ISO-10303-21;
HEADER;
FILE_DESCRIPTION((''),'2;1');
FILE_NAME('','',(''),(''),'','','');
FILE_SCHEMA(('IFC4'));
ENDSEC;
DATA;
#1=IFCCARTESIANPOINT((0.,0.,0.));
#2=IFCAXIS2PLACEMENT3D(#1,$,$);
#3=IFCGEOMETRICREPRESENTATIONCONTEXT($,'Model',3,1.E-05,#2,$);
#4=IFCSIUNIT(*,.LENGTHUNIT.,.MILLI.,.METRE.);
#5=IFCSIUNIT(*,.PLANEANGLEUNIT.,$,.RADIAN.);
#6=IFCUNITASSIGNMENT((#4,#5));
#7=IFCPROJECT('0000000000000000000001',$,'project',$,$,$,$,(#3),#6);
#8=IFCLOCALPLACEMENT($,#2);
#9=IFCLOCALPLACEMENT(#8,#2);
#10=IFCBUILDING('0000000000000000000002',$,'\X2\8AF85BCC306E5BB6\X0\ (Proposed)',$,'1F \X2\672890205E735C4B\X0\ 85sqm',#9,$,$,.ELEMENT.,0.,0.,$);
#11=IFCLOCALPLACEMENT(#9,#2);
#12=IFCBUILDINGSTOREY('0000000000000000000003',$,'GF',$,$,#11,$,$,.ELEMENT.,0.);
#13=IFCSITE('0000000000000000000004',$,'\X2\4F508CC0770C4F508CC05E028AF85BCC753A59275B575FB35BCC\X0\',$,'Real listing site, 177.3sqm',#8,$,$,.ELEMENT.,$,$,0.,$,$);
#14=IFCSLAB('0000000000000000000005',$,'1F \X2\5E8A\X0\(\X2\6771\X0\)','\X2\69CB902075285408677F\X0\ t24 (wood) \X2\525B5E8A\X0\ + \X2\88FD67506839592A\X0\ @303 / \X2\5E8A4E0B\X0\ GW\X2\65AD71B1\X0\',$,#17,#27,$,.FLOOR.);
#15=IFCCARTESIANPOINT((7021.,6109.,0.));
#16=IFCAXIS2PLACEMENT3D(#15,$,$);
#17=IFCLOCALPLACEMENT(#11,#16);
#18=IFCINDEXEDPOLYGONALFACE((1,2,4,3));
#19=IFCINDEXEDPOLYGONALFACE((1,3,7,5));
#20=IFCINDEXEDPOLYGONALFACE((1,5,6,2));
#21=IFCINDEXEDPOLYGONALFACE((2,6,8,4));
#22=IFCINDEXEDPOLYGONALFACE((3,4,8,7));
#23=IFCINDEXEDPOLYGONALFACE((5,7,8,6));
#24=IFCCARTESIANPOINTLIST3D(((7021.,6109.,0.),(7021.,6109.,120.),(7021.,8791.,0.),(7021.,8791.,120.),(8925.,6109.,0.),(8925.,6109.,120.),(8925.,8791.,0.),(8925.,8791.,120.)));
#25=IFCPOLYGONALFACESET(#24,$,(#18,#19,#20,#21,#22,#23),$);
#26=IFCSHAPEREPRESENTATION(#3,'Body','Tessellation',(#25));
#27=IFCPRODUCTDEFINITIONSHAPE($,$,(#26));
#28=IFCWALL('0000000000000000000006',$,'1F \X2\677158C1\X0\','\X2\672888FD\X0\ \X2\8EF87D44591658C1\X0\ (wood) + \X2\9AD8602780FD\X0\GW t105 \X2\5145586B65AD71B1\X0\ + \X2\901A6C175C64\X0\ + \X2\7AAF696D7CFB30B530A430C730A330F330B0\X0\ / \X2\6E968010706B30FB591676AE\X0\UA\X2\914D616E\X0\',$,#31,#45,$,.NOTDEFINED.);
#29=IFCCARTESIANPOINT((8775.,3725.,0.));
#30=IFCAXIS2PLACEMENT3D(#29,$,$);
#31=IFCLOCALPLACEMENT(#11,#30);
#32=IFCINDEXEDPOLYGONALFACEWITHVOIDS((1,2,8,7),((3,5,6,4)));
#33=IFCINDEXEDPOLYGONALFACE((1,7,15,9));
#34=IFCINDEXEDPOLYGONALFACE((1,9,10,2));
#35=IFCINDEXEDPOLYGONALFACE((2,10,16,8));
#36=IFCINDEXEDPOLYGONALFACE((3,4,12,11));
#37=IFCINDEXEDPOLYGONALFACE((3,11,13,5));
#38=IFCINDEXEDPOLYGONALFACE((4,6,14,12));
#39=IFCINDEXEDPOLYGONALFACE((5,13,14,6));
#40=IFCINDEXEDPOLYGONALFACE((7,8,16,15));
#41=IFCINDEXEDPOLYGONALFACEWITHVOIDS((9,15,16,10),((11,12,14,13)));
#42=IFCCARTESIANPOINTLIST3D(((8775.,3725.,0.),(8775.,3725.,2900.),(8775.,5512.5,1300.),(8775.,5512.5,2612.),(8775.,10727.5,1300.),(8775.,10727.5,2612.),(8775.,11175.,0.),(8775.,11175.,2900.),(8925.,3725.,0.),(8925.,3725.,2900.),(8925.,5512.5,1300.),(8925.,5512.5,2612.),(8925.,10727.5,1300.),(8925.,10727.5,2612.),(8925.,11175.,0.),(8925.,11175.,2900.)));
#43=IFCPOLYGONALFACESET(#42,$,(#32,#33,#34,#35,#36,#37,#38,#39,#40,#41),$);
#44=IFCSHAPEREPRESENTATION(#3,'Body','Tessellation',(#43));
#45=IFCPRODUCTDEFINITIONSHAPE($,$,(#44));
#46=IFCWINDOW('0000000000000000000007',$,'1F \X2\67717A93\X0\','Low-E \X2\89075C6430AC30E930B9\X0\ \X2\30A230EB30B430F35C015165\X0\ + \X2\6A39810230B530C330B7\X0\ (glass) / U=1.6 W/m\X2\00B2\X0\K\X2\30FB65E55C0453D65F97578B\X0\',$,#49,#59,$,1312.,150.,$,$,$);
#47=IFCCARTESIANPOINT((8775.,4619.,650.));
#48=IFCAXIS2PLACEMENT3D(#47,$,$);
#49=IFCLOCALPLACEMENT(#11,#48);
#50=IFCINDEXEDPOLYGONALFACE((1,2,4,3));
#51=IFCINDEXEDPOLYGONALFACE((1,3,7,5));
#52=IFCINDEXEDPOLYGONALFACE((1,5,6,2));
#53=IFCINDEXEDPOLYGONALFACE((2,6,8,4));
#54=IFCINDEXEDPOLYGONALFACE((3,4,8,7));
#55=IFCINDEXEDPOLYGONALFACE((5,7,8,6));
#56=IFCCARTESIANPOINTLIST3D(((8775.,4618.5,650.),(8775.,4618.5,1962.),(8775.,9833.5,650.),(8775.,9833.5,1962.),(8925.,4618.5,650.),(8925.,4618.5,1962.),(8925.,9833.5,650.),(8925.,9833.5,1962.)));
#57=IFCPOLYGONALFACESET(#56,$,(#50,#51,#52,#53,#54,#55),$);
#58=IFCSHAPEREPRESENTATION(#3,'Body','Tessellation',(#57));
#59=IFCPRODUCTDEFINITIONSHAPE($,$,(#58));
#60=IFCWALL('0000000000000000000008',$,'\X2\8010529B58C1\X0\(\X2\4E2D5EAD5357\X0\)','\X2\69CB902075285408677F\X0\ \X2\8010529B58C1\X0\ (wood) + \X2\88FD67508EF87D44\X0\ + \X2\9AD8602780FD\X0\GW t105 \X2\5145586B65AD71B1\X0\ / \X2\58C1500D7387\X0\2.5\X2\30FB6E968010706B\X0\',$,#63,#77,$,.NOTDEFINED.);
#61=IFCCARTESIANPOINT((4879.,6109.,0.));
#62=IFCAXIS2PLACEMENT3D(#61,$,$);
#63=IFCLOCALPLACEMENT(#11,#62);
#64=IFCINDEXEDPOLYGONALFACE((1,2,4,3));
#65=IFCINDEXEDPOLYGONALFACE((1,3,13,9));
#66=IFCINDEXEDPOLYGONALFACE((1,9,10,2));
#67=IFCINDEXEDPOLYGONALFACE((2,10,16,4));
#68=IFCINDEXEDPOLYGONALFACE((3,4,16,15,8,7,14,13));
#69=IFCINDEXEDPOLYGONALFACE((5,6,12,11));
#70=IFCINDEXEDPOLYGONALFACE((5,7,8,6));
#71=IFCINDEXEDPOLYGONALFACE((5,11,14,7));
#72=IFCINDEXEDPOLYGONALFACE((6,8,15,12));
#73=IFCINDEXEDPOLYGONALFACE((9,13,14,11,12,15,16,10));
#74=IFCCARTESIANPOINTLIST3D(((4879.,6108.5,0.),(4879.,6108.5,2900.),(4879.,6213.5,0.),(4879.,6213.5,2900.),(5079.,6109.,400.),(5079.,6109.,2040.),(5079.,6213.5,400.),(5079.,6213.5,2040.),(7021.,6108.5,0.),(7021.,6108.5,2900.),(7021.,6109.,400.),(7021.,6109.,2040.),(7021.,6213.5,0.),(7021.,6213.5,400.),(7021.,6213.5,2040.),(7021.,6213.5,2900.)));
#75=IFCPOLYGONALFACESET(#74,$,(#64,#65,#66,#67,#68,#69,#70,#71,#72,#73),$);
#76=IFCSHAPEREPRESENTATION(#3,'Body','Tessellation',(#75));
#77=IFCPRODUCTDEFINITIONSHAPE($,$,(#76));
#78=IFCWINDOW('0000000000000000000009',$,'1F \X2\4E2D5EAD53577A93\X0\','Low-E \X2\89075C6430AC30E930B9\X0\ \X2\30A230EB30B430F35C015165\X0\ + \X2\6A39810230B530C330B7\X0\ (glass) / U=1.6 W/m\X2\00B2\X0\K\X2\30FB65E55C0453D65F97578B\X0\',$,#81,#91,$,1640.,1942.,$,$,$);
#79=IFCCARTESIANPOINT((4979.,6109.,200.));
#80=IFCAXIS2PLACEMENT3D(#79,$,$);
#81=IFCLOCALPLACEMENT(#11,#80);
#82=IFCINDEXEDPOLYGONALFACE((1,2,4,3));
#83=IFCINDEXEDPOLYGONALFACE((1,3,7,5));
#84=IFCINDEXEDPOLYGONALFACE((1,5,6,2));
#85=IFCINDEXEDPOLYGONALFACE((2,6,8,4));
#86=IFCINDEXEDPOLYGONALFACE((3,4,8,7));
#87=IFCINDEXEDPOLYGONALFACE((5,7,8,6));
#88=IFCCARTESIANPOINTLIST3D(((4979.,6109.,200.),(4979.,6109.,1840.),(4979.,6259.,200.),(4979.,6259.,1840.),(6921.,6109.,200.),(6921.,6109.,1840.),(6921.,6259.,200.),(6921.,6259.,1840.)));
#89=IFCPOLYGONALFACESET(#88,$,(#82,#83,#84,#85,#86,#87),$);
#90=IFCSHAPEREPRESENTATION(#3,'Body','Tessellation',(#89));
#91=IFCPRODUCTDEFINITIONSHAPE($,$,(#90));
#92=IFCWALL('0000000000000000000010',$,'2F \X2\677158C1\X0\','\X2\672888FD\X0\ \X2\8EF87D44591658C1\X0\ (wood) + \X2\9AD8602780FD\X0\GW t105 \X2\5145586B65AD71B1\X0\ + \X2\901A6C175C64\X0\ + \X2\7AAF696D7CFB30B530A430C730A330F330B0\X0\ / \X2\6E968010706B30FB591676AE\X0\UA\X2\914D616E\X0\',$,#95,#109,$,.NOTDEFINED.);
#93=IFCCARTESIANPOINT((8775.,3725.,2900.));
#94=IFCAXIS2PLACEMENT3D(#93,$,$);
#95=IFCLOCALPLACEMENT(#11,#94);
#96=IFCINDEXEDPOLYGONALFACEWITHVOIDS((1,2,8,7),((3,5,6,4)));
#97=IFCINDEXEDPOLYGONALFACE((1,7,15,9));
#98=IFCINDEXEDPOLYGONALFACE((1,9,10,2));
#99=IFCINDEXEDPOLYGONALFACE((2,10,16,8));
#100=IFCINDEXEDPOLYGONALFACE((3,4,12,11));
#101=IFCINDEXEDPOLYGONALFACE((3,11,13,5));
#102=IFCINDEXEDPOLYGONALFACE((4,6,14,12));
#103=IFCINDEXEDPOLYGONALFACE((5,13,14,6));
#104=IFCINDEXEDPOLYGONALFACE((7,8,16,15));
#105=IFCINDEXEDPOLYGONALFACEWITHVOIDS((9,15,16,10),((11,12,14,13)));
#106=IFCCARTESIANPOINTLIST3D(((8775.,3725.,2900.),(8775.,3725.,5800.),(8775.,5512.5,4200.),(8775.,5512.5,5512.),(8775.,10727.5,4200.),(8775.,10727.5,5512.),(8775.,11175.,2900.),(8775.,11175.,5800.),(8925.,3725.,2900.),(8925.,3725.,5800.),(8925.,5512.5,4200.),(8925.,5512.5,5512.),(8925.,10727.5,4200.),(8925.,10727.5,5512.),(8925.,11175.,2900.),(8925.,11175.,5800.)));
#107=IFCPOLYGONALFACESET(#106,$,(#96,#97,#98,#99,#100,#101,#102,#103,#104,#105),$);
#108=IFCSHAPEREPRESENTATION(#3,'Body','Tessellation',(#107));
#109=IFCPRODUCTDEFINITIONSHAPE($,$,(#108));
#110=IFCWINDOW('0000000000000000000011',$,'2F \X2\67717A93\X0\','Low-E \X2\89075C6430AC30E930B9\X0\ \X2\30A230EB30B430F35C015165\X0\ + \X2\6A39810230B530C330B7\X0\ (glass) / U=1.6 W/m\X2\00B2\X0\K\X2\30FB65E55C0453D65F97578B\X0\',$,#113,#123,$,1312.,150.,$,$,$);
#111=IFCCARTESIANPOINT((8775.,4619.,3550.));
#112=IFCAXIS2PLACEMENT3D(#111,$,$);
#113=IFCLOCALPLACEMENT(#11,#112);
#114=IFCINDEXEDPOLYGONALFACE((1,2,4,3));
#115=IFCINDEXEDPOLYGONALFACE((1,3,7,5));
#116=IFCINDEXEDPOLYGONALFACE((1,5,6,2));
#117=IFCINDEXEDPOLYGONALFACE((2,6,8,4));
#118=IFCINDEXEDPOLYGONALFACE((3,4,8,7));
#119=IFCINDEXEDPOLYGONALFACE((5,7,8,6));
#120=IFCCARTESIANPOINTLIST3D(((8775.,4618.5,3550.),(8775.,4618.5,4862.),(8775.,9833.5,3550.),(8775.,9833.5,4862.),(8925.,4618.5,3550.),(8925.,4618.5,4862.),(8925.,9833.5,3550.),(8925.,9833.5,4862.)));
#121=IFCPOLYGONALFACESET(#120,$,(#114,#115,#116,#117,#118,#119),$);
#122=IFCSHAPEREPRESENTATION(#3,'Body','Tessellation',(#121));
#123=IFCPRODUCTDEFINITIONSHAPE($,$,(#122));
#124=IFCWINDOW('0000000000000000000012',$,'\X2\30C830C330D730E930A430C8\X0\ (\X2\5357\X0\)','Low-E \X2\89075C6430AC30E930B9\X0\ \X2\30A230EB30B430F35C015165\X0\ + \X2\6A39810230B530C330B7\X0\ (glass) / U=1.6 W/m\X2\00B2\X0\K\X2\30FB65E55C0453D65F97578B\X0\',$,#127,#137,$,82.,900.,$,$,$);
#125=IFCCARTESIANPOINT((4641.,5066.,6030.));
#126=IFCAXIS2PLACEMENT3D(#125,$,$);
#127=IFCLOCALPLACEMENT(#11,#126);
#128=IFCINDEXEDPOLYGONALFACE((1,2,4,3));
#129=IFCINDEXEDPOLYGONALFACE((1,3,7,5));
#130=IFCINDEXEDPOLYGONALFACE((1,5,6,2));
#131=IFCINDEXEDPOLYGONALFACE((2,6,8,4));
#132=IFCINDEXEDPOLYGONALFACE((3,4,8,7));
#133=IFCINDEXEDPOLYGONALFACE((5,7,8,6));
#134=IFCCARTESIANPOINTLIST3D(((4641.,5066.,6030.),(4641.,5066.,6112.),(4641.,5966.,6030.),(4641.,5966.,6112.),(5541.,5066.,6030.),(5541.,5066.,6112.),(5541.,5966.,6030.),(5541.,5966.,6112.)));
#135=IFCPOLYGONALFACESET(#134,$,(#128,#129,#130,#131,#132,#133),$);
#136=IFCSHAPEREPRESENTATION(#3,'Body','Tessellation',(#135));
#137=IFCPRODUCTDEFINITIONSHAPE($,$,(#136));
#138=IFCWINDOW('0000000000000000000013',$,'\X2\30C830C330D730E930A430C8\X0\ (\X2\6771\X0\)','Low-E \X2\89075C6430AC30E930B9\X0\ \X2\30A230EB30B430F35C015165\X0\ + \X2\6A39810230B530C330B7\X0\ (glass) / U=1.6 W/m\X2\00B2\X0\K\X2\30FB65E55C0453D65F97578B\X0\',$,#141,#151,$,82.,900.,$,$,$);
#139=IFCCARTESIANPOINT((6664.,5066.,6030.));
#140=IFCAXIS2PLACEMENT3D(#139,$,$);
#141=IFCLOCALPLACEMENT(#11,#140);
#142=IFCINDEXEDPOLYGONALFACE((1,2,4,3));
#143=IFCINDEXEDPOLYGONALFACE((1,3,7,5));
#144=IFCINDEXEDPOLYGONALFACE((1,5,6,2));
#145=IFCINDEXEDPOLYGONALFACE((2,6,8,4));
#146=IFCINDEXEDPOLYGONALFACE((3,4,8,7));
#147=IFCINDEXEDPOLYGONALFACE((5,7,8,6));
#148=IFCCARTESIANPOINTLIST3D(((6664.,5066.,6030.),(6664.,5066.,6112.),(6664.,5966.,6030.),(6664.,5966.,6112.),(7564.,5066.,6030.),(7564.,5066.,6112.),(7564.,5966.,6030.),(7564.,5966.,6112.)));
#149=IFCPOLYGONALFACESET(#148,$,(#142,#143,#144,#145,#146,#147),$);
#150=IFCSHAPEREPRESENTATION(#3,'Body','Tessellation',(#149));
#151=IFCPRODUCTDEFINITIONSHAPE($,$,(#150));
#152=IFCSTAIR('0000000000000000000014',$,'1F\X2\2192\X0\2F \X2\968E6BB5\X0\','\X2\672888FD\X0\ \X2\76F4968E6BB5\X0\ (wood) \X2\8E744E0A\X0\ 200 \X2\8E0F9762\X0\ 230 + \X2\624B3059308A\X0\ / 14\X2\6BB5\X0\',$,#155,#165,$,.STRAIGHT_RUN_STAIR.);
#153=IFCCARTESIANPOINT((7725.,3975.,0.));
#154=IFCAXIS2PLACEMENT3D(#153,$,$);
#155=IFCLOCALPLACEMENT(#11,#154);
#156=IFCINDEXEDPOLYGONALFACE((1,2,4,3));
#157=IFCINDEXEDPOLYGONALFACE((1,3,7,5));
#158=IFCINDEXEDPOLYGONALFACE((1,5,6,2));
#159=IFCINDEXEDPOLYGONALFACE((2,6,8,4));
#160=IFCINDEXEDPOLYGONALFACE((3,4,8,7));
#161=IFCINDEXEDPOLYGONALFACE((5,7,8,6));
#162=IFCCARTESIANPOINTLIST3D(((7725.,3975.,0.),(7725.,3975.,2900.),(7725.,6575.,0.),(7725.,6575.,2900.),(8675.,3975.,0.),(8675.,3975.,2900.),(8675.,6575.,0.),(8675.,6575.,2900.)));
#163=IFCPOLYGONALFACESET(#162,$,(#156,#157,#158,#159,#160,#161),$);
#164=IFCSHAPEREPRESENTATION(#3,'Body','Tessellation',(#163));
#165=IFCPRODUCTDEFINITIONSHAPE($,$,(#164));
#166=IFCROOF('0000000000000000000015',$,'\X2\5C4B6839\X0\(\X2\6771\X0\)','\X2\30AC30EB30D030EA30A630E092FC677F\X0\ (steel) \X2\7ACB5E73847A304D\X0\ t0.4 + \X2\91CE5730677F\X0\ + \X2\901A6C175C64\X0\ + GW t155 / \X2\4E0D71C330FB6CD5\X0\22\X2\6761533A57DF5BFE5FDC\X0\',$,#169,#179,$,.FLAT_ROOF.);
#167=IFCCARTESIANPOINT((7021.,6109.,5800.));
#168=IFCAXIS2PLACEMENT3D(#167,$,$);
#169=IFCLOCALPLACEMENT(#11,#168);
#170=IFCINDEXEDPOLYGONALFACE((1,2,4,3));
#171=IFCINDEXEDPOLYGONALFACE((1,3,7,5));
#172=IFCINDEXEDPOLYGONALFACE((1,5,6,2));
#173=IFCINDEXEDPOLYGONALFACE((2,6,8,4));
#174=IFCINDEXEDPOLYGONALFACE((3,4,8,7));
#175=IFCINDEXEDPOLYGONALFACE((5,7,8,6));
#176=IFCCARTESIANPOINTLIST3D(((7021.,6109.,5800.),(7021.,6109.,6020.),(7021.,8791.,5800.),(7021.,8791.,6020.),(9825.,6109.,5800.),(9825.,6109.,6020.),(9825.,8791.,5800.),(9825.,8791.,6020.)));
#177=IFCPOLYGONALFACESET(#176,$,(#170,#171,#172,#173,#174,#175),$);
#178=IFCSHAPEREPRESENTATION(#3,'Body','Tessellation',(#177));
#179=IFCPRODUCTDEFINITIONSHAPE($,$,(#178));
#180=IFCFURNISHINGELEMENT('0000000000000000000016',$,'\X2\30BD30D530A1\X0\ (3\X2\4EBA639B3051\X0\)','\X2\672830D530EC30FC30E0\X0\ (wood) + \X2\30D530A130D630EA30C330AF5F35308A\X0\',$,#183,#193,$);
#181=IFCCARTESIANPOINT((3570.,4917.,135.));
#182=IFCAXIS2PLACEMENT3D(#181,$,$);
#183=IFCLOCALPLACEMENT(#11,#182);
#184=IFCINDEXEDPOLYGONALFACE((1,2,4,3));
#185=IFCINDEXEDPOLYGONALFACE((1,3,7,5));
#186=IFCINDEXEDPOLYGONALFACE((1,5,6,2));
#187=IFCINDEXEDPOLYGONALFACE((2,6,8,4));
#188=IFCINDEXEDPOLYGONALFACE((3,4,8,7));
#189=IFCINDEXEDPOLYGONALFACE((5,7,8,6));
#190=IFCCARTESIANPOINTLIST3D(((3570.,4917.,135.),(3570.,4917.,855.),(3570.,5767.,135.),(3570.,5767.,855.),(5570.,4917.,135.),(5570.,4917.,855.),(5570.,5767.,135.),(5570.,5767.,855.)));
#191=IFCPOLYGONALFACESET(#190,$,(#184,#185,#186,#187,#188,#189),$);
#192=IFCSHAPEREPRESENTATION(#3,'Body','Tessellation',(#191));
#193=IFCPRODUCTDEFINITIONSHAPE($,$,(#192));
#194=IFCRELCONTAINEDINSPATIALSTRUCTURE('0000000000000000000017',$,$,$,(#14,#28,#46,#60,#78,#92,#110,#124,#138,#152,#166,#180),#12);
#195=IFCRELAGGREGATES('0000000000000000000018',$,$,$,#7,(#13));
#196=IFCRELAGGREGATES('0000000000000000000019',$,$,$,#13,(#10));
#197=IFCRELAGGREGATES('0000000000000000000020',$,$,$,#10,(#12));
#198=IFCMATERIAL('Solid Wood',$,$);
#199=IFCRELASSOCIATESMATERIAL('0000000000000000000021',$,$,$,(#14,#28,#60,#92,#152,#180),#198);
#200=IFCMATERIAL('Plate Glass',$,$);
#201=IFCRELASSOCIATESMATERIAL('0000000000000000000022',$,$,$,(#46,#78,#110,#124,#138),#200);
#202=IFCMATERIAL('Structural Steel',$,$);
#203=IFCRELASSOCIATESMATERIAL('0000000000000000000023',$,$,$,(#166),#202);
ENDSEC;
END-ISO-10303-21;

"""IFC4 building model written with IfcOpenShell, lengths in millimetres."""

from ifc_helpers import new_model, si_unit, frame, frame_2d, origin, place, context, project, spatial, rectangle, extrude, material, element, fill, save


model = new_model("IFC4")

# Units and contexts
model_context = context("Model", 3, precision=1e-05, world=origin())
ifc_project = project(units=[si_unit("LENGTHUNIT", "METRE", prefix="MILLI"), si_unit("PLANEANGLEUNIT", "RADIAN")], contexts=[model_context])

# Site, building, storey
site_placement = place(None, origin())
site = spatial("IfcSite", under=ifc_project, at=site_placement, Name="佐賀県佐賀市諸富町大字徳富", ObjectType="Real listing site, 177.3sqm", CompositionType="ELEMENT", RefElevation=0.0)
building_placement = place(site_placement, origin())
building = spatial("IfcBuilding", under=site, at=building_placement, Name="諸富の家 (Proposed)", ObjectType="1F 木造平屋 85sqm", CompositionType="ELEMENT", ElevationOfRefHeight=0.0, ElevationOfTerrain=0.0)
storey_placement = place(building_placement, origin())
storey = spatial("IfcBuildingStorey", under=building, at=storey_placement, Name="GF", CompositionType="ELEMENT", Elevation=0.0)

# Slab
ifc_material_1 = material(Name="Solid Wood")
slab_placement = place(storey_placement, frame((7021.0, 6109.0, 0.0)))
element("IfcSlab", 1, at=slab_placement, inside=storey, material=ifc_material_1, Name="1F 床(東)", Description="構造用合板 t24 (wood) 剛床 + 製材根太 @303 / 床下 GW断熱", PredefinedType="FLOOR", context=model_context, shape_type="SweptSolid", body=[
    extrude(rectangle(XDim=1904.0, YDim=2682.0, at=frame_2d((952.0, 1341.0))), frame((7021.0, 6109.0, 0.0)), (0.0, 0.0, 1.0), 120.0),
])

# Walls, openings, windows
wall_1_placement = place(storey_placement, frame((8775.0, 3725.0, 0.0)))
wall_1 = element("IfcWall", 2, at=wall_1_placement, inside=storey, material=ifc_material_1, Name="1F 東壁", Description="木製 軸組外壁 (wood) + 高性能GW t105 充填断熱 + 通気層 + 窯業系サイディング / 準耐火・外皮UA配慮", PredefinedType="NOTDEFINED", context=model_context, shape_type="SweptSolid", body=[
    extrude(rectangle(XDim=150.0, YDim=7450.0, at=frame_2d((75.0, 3725.0))), frame((8775.0, 3725.0, 0.0)), (0.0, 0.0, 1.0), 2900.0),
])
opening_1_placement = place(storey_placement, frame((8775.0, 4619.0, 650.0)))
opening_1 = element("IfcOpeningElement", 3, at=opening_1_placement, cuts=wall_1, PredefinedType="NOTDEFINED", context=model_context, shape_type="SweptSolid", body=[
    extrude(rectangle(XDim=150.0, YDim=5215.0, at=frame_2d((75.0, 2607.0))), frame((8775.0, 4619.0, 650.0)), (0.0, 0.0, 1.0), 1312.0),
])
ifc_material_2 = material(Name="Plate Glass")
window_1_placement = place(storey_placement, frame((8775.0, 4619.0, 650.0)))
window_1 = element("IfcWindow", 4, at=window_1_placement, inside=storey, material=ifc_material_2, Name="1F 東窓", Description="Low-E 複層ガラス アルゴン封入 + 樹脂サッシ (glass) / U=1.6 W/m²K・日射取得型", OverallHeight=1312.0, OverallWidth=150.0, context=model_context, shape_type="SweptSolid", body=[
    extrude(rectangle(XDim=150.0, YDim=5215.0, at=frame_2d((75.0, 2607.0))), frame((8775.0, 4619.0, 650.0)), (0.0, 0.0, 1.0), 1312.0),
])
fill(opening_1, window_1)
wall_2_placement = place(storey_placement, frame((4879.0, 6109.0, 0.0)))
wall_2 = element("IfcWall", 5, at=wall_2_placement, inside=storey, material=ifc_material_1, Name="耐力壁(中庭南)", Description="構造用合板 耐力壁 (wood) + 製材軸組 + 高性能GW t105 充填断熱 / 壁倍率2.5・準耐火", PredefinedType="NOTDEFINED", context=model_context, shape_type="SweptSolid", body=[
    extrude(rectangle(XDim=2142.0, YDim=105.0, at=frame_2d((1071.0, 52.0))), frame((4879.0, 6109.0, 0.0)), (0.0, 0.0, 1.0), 2900.0),
])
opening_2_placement = place(storey_placement, frame((4979.0, 6109.0, 200.0)))
opening_2 = element("IfcOpeningElement", 6, at=opening_2_placement, cuts=wall_2, PredefinedType="NOTDEFINED", context=model_context, shape_type="SweptSolid", body=[
    extrude(rectangle(XDim=1942.0, YDim=150.0, at=frame_2d((971.0, 75.0))), frame((4979.0, 6109.0, 200.0)), (0.0, 0.0, 1.0), 1640.0),
])
window_2_placement = place(storey_placement, frame((4979.0, 6109.0, 200.0)))
window_2 = element("IfcWindow", 7, at=window_2_placement, inside=storey, material=ifc_material_2, Name="1F 中庭南窓", Description="Low-E 複層ガラス アルゴン封入 + 樹脂サッシ (glass) / U=1.6 W/m²K・日射取得型", OverallHeight=1640.0, OverallWidth=1942.0, context=model_context, shape_type="SweptSolid", body=[
    extrude(rectangle(XDim=1942.0, YDim=150.0, at=frame_2d((971.0, 75.0))), frame((4979.0, 6109.0, 200.0)), (0.0, 0.0, 1.0), 1640.0),
])
fill(opening_2, window_2)

# Wall, opening, window
wall_3_placement = place(storey_placement, frame((8775.0, 3725.0, 2900.0)))
wall_3 = element("IfcWall", 8, at=wall_3_placement, inside=storey, material=ifc_material_1, Name="2F 東壁", Description="木製 軸組外壁 (wood) + 高性能GW t105 充填断熱 + 通気層 + 窯業系サイディング / 準耐火・外皮UA配慮", PredefinedType="NOTDEFINED", context=model_context, shape_type="SweptSolid", body=[
    extrude(rectangle(XDim=150.0, YDim=7450.0, at=frame_2d((75.0, 3725.0))), frame((8775.0, 3725.0, 2900.0)), (0.0, 0.0, 1.0), 2900.0),
])
opening_3_placement = place(storey_placement, frame((8775.0, 4619.0, 3550.0)))
opening_3 = element("IfcOpeningElement", 9, at=opening_3_placement, cuts=wall_3, PredefinedType="NOTDEFINED", context=model_context, shape_type="SweptSolid", body=[
    extrude(rectangle(XDim=150.0, YDim=5215.0, at=frame_2d((75.0, 2607.0))), frame((8775.0, 4619.0, 3550.0)), (0.0, 0.0, 1.0), 1312.0),
])
window_3_placement = place(storey_placement, frame((8775.0, 4619.0, 3550.0)))
window_3 = element("IfcWindow", 10, at=window_3_placement, inside=storey, material=ifc_material_2, Name="2F 東窓", Description="Low-E 複層ガラス アルゴン封入 + 樹脂サッシ (glass) / U=1.6 W/m²K・日射取得型", OverallHeight=1312.0, OverallWidth=150.0, context=model_context, shape_type="SweptSolid", body=[
    extrude(rectangle(XDim=150.0, YDim=5215.0, at=frame_2d((75.0, 2607.0))), frame((8775.0, 4619.0, 3550.0)), (0.0, 0.0, 1.0), 1312.0),
])
fill(opening_3, window_3)

# Windows
window_4_placement = place(storey_placement, frame((4641.0, 5066.0, 6030.0)))
element("IfcWindow", 11, at=window_4_placement, inside=storey, material=ifc_material_2, Name="トップライト (南)", Description="Low-E 複層ガラス アルゴン封入 + 樹脂サッシ (glass) / U=1.6 W/m²K・日射取得型", OverallHeight=82.0, OverallWidth=900.0, context=model_context, shape_type="SweptSolid", body=[
    extrude(rectangle(XDim=900.0, YDim=900.0, at=frame_2d((450.0, 450.0))), frame((4641.0, 5066.0, 6030.0)), (0.0, 0.0, 1.0), 82.0),
])
window_5_placement = place(storey_placement, frame((6664.0, 5066.0, 6030.0)))
element("IfcWindow", 12, at=window_5_placement, inside=storey, material=ifc_material_2, Name="トップライト (東)", Description="Low-E 複層ガラス アルゴン封入 + 樹脂サッシ (glass) / U=1.6 W/m²K・日射取得型", OverallHeight=82.0, OverallWidth=900.0, context=model_context, shape_type="SweptSolid", body=[
    extrude(rectangle(XDim=900.0, YDim=900.0, at=frame_2d((450.0, 450.0))), frame((6664.0, 5066.0, 6030.0)), (0.0, 0.0, 1.0), 82.0),
])

# Stair
stair_placement = place(storey_placement, frame((7725.0, 3975.0, 0.0)))
element("IfcStair", 13, at=stair_placement, inside=storey, material=ifc_material_1, Name="1F→2F 階段", Description="木製 直階段 (wood) 蹴上 200 踏面 230 + 手すり / 14段", PredefinedType="STRAIGHT_RUN_STAIR", context=model_context, shape_type="SweptSolid", body=[
    extrude(rectangle(XDim=950.0, YDim=2600.0, at=frame_2d((475.0, 1300.0))), frame((7725.0, 3975.0, 0.0)), (0.0, 0.0, 1.0), 2900.0),
])

# Roof
ifc_material_3 = material(Name="Structural Steel")
roof_placement = place(storey_placement, frame((7021.0, 6109.0, 5800.0)))
element("IfcRoof", 14, at=roof_placement, inside=storey, material=ifc_material_3, Name="屋根(東)", Description="ガルバリウム鋼板 (steel) 立平葺き t0.4 + 野地板 + 通気層 + GW t155 / 不燃・法22条区域対応", PredefinedType="FLAT_ROOF", context=model_context, shape_type="SweptSolid", body=[
    extrude(rectangle(XDim=2804.0, YDim=2682.0, at=frame_2d((1402.0, 1341.0))), frame((7021.0, 6109.0, 5800.0)), (0.0, 0.0, 1.0), 220.0),
])

# Furnishing element
furnishing_1_placement = place(storey_placement, frame((3570.0, 4917.0, 135.0)))
element("IfcFurnishingElement", 15, at=furnishing_1_placement, inside=storey, material=ifc_material_1, Name="ソファ (3人掛け)", Description="木フレーム (wood) + ファブリック張り", context=model_context, shape_type="SweptSolid", body=[
    extrude(rectangle(XDim=2000.0, YDim=850.0, at=frame_2d((1000.0, 425.0))), frame((3570.0, 4917.0, 135.0)), (0.0, 0.0, 1.0), 720.0),
])

save(model, "model.ifc")
